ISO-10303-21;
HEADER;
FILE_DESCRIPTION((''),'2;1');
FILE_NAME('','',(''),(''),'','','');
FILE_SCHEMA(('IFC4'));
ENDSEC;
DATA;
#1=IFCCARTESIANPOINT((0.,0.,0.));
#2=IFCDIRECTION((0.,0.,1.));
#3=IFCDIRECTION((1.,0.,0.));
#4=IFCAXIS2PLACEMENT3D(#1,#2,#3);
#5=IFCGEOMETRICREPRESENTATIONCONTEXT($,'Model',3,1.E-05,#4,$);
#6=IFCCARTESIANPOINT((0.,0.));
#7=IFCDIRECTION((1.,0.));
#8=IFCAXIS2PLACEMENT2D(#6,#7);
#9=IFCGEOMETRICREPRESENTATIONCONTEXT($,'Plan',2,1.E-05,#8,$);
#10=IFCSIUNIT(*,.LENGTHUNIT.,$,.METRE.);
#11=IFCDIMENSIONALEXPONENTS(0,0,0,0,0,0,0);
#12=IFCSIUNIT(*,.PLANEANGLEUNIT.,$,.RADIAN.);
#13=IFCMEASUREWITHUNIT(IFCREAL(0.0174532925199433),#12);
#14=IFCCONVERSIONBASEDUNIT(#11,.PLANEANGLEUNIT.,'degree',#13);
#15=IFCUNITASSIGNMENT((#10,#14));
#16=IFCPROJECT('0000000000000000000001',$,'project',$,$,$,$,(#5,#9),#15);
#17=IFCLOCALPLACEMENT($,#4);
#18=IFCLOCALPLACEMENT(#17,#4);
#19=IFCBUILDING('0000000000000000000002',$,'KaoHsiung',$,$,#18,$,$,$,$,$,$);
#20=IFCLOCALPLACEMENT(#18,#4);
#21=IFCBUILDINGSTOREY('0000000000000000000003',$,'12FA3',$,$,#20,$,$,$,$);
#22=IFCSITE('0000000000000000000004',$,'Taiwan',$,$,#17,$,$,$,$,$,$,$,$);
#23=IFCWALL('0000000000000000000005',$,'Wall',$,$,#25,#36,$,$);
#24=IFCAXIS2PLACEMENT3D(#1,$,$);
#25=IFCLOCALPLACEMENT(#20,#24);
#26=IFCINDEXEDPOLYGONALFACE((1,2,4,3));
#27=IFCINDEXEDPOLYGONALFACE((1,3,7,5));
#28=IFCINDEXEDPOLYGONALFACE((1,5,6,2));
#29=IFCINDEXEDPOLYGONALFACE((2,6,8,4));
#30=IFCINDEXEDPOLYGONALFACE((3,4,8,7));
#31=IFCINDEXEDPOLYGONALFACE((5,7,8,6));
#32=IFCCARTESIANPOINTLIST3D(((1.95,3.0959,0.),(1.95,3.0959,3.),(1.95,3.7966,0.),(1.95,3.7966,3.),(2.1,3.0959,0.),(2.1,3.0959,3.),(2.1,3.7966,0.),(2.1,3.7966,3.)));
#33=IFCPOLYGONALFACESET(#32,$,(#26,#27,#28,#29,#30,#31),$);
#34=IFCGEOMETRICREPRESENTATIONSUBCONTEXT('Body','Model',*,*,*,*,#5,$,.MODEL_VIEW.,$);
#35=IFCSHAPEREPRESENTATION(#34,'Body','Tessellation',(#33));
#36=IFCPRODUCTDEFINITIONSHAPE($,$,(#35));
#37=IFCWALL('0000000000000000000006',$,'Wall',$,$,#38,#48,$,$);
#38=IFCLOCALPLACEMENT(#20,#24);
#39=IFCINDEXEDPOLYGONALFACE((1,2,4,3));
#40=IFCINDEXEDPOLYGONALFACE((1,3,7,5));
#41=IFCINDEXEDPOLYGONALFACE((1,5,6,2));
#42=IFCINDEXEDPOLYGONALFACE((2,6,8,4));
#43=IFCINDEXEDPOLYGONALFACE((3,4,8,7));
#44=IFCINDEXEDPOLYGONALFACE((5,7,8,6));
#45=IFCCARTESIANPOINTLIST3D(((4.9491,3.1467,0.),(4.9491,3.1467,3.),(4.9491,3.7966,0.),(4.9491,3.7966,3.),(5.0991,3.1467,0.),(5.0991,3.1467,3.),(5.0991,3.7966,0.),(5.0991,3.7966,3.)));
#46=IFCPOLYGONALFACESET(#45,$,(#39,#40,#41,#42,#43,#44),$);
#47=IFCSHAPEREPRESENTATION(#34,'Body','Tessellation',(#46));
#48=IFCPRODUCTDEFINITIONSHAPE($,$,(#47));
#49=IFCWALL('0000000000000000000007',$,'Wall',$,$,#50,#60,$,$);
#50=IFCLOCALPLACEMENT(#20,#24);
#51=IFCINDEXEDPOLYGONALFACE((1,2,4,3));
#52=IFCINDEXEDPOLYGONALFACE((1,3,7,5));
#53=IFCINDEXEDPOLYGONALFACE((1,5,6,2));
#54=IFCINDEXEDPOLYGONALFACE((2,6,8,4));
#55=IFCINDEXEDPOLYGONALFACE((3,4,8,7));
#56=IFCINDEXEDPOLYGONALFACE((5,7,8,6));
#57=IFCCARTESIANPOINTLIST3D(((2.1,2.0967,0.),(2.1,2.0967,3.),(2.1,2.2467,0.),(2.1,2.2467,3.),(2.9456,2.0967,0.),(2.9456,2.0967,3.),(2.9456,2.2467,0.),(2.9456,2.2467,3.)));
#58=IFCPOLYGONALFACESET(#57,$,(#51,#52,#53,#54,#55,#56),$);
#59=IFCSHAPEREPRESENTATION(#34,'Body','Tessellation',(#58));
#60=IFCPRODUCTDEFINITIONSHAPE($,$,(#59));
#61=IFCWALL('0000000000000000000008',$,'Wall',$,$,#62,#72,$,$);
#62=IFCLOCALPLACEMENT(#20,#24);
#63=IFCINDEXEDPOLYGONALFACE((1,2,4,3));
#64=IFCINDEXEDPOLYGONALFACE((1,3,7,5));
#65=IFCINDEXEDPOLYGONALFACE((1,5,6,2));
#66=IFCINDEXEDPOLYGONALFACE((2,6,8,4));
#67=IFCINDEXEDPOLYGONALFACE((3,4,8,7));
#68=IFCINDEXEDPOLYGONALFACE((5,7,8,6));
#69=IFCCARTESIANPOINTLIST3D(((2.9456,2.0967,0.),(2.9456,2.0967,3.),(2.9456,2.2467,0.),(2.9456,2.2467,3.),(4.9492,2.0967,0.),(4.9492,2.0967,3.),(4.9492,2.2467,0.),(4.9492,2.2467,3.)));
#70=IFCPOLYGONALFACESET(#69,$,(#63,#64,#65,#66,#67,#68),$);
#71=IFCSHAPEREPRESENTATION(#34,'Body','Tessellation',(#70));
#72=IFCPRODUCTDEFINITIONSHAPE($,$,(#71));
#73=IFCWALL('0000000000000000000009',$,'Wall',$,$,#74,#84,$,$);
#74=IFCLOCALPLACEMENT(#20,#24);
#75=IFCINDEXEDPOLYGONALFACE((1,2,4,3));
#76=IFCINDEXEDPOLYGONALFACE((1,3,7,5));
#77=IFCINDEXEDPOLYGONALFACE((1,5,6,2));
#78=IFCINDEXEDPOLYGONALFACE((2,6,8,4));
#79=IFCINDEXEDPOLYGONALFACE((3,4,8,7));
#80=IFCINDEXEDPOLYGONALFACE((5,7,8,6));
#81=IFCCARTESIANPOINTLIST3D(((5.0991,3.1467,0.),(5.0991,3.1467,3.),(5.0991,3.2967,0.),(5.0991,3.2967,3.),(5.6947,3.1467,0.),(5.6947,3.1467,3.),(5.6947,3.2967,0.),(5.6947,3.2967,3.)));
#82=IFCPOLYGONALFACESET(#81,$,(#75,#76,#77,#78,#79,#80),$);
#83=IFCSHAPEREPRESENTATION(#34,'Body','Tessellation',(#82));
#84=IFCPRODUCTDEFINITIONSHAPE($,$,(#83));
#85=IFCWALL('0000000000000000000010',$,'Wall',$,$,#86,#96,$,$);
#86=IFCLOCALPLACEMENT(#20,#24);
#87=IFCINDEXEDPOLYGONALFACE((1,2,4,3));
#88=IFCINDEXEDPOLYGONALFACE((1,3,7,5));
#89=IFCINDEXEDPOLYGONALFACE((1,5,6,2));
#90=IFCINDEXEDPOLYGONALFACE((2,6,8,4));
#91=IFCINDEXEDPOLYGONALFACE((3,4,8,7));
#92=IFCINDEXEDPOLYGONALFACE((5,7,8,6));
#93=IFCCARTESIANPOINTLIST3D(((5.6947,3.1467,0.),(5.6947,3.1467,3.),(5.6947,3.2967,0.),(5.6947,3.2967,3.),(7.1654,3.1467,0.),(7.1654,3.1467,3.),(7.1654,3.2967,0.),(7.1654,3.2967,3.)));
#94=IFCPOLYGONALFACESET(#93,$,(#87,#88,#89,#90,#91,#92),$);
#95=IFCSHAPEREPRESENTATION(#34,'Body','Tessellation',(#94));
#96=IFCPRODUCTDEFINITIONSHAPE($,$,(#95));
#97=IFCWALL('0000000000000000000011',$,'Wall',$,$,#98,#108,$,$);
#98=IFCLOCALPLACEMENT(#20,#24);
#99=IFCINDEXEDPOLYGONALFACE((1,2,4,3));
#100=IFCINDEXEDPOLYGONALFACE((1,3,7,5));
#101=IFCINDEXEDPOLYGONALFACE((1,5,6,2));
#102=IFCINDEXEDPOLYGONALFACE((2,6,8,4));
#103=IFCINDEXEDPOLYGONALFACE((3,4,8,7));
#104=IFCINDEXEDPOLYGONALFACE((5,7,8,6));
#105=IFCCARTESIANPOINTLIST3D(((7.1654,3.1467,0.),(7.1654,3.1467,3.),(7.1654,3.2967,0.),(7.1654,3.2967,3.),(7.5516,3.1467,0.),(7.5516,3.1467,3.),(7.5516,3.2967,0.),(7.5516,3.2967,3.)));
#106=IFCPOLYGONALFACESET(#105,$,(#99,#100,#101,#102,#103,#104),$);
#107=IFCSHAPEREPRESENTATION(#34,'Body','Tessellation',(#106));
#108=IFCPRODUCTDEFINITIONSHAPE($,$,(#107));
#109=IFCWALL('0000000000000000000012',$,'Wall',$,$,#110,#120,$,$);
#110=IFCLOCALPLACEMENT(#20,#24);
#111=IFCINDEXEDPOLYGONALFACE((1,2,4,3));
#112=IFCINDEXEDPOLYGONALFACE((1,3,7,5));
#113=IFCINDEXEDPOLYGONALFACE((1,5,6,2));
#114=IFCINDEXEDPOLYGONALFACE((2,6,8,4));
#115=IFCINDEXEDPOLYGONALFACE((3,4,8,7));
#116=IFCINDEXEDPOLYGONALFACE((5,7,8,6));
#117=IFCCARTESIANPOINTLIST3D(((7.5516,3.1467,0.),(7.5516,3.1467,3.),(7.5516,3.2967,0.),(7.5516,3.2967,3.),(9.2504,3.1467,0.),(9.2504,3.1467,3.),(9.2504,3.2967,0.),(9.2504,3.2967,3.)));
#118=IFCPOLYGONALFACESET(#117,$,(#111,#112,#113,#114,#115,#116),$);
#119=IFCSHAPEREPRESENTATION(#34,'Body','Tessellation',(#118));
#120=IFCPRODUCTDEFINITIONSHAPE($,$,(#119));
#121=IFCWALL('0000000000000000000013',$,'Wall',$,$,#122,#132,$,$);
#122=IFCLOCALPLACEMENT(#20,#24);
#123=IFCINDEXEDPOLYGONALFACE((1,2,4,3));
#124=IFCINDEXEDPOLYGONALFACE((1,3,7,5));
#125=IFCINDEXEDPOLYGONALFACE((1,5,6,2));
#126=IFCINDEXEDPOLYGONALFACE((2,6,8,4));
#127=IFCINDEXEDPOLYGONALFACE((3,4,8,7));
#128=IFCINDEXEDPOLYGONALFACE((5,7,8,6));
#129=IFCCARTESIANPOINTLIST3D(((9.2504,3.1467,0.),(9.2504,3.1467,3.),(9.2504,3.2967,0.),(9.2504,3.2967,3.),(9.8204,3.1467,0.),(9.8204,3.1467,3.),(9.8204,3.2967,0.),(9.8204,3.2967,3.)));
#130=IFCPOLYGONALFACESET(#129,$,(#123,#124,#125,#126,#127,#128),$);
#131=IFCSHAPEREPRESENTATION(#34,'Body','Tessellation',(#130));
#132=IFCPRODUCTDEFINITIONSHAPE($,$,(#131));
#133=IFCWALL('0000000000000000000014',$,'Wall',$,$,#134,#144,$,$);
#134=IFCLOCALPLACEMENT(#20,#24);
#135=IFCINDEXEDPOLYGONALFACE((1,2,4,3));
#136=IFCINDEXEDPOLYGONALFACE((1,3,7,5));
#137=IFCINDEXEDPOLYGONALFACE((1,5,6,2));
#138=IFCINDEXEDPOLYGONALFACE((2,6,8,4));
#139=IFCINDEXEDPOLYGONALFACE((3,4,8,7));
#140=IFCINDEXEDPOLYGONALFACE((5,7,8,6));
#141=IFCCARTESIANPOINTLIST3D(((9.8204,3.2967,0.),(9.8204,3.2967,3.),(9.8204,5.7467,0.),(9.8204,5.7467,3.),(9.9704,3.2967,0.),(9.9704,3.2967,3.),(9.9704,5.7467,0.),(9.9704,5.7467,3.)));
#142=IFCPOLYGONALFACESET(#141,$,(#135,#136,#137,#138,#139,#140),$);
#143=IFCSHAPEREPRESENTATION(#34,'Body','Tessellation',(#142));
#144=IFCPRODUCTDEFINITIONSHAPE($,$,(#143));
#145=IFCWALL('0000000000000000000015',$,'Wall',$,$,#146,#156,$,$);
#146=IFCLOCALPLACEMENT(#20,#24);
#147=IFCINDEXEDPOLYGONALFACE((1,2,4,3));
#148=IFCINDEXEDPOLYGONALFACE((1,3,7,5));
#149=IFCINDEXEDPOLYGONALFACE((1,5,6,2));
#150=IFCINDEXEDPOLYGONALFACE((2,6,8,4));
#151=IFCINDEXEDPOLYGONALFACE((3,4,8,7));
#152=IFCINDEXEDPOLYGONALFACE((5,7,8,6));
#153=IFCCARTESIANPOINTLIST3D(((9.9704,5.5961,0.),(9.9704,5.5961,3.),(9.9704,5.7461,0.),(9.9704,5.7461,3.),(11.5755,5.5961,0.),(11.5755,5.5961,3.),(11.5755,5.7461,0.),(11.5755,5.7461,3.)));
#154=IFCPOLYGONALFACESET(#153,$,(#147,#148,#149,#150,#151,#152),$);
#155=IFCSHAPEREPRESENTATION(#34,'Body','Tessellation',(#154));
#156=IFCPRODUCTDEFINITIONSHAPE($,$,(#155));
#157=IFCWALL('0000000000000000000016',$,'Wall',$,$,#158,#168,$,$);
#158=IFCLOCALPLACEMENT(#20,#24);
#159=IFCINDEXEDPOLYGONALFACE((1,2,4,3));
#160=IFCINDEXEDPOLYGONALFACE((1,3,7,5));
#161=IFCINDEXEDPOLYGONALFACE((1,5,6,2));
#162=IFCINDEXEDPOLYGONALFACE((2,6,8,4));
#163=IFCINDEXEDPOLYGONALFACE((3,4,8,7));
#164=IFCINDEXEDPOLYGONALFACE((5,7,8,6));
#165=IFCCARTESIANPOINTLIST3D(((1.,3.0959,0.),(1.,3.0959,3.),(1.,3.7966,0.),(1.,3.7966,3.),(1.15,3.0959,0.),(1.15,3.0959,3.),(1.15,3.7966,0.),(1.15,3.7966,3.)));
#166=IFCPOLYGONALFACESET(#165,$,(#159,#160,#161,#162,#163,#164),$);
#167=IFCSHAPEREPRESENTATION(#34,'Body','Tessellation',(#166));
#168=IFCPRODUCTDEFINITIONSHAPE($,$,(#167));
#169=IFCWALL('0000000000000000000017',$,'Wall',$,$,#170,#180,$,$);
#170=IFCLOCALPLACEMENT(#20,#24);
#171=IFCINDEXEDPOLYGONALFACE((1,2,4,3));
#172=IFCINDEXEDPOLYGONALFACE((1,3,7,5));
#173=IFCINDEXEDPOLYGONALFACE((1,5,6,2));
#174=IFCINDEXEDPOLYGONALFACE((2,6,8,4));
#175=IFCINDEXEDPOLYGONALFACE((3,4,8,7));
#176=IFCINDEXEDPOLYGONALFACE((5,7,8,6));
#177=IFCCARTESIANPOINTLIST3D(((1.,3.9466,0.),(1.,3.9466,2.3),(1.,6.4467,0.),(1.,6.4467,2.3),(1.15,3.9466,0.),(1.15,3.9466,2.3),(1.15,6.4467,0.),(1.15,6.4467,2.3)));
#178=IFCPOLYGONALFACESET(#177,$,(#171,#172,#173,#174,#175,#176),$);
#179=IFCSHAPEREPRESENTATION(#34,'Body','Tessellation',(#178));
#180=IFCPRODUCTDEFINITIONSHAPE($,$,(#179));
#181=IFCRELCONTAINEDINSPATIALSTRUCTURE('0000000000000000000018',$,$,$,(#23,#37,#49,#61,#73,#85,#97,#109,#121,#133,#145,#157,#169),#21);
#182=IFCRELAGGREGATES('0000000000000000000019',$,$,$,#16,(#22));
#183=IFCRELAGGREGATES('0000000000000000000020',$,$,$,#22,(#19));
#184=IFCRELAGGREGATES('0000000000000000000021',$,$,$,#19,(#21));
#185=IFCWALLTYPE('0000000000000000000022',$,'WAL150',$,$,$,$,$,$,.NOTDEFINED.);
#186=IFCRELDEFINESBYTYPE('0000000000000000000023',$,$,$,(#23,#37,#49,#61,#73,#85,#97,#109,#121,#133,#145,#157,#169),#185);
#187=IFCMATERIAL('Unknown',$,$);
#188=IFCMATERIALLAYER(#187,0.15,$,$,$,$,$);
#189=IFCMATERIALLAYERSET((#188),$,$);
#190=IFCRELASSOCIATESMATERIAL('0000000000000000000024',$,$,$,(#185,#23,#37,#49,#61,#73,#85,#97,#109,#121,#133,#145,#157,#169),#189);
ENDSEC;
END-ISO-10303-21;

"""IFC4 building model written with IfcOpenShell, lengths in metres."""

from ifc_helpers import new_model, entity, si_unit, converted_unit, frame, origin_with_axes, origin_2d_with_axis, place, context, subcontext, project, spatial, line, indexed_curve, outline, extrude, material, layer, layer_set, layer_usage, type_object, element, save


model = new_model("IFC4")

# Units and contexts
model_context = context("Model", 3, precision=1e-05, world=origin_with_axes())
plan_context = context("Plan", 2, precision=1e-05, world=origin_2d_with_axis())
body_context_1 = subcontext(model_context, "Body", "Model", "MODEL_VIEW")
ifc_project = project(units=[si_unit("LENGTHUNIT", "METRE"), converted_unit("PLANEANGLEUNIT", "degree", entity("IfcReal", 0.0174532925199433), si_unit("PLANEANGLEUNIT", "RADIAN"), dimensions=[0, 0, 0, 0, 0, 0, 0])], contexts=[model_context, plan_context])

# Site, building, storey
site_placement = place(None, origin_with_axes())
site = spatial("IfcSite", under=ifc_project, at=site_placement, Name="Taiwan")
building_placement = place(site_placement, origin_with_axes())
building = spatial("IfcBuilding", under=site, at=building_placement, Name="KaoHsiung")
storey_placement = place(building_placement, origin_with_axes())
storey = spatial("IfcBuildingStorey", under=building, at=storey_placement, Name="12FA3")

# Shared definitions
ifc_material = material(Name="Unknown")

# Walls
ifc_layer_1 = layer(ifc_material, 0.15)
ifc_layer_set_1 = layer_set([ifc_layer_1])
wall_type_1 = type_object("IfcWallType", Name="WAL150", PredefinedType="NOTDEFINED", material=ifc_layer_set_1)
ifc_layer_usage_1 = layer_usage(ifc_layer_set_1, "AXIS2", "POSITIVE", 0.0)
wall_1_placement = place(storey_placement, frame((1.95, 3.7966, 0.0), z_axis=(0.0, 0.0, 1.0), x_axis=(0.0, -1.0, 0.0)))
element("IfcWall", 1, at=wall_1_placement, inside=storey, type_object=wall_type_1, material=ifc_layer_usage_1, Name="Wall", context=body_context_1, shape_type="SweptSolid", body=[
    extrude(outline(indexed_curve([(0.0, 0.0), (0.0, 0.15), (0.7007, 0.15), (0.7007, 0.0)], segments=[line(1, 2, 3, 4, 1)])), origin_with_axes(), (0.0, 0.0, 1.0), 3.0),
])
ifc_layer_usage_2 = layer_usage(ifc_layer_set_1, "AXIS2", "POSITIVE", 0.0)
wall_2_placement = place(storey_placement, frame((4.9491, 3.7966, 0.0), z_axis=(0.0, 0.0, 1.0), x_axis=(0.0, -1.0, 0.0)))
element("IfcWall", 2, at=wall_2_placement, inside=storey, type_object=wall_type_1, material=ifc_layer_usage_2, Name="Wall", context=body_context_1, shape_type="SweptSolid", body=[
    extrude(outline(indexed_curve([(0.0, 0.0), (0.0, 0.15), (0.6499, 0.15), (0.6499, 0.0)], segments=[line(1, 2, 3, 4, 1)])), origin_with_axes(), (0.0, 0.0, 1.0), 3.0),
])
ifc_layer_usage_3 = layer_usage(ifc_layer_set_1, "AXIS2", "POSITIVE", 0.0)
wall_3_placement = place(storey_placement, frame((2.1, 2.0967, 0.0), z_axis=(0.0, 0.0, 1.0), x_axis=(1.0, 0.0, 0.0)))
element("IfcWall", 3, at=wall_3_placement, inside=storey, type_object=wall_type_1, material=ifc_layer_usage_3, Name="Wall", context=body_context_1, shape_type="SweptSolid", body=[
    extrude(outline(indexed_curve([(0.0, 0.0), (0.0, 0.15), (0.8456, 0.15), (0.8456, 0.0)], segments=[line(1, 2, 3, 4, 1)])), origin_with_axes(), (0.0, 0.0, 1.0), 3.0),
])
ifc_layer_usage_4 = layer_usage(ifc_layer_set_1, "AXIS2", "POSITIVE", 0.0)
wall_4_placement = place(storey_placement, frame((2.9456, 2.0967, 0.0), z_axis=(0.0, 0.0, 1.0), x_axis=(1.0, 0.0, 0.0)))
element("IfcWall", 4, at=wall_4_placement, inside=storey, type_object=wall_type_1, material=ifc_layer_usage_4, Name="Wall", context=body_context_1, shape_type="SweptSolid", body=[
    extrude(outline(indexed_curve([(0.0, 0.0), (0.0, 0.15), (2.0037, 0.15), (2.0037, 0.0)], segments=[line(1, 2, 3, 4, 1)])), origin_with_axes(), (0.0, 0.0, 1.0), 3.0),
])
ifc_layer_usage_5 = layer_usage(ifc_layer_set_1, "AXIS2", "POSITIVE", 0.0)
wall_5_placement = place(storey_placement, frame((5.0991, 3.1467, 0.0), z_axis=(0.0, 0.0, 1.0), x_axis=(1.0, 0.0, 0.0)))
element("IfcWall", 5, at=wall_5_placement, inside=storey, type_object=wall_type_1, material=ifc_layer_usage_5, Name="Wall", context=body_context_1, shape_type="SweptSolid", body=[
    extrude(outline(indexed_curve([(0.0, 0.0), (0.0, 0.15), (0.5956, 0.15), (0.5956, 0.0)], segments=[line(1, 2, 3, 4, 1)])), origin_with_axes(), (0.0, 0.0, 1.0), 3.0),
])
ifc_layer_usage_6 = layer_usage(ifc_layer_set_1, "AXIS2", "POSITIVE", 0.0)
wall_6_placement = place(storey_placement, frame((5.6947, 3.1467, 0.0), z_axis=(0.0, 0.0, 1.0), x_axis=(1.0, 0.0, 0.0)))
element("IfcWall", 6, at=wall_6_placement, inside=storey, type_object=wall_type_1, material=ifc_layer_usage_6, Name="Wall", context=body_context_1, shape_type="SweptSolid", body=[
    extrude(outline(indexed_curve([(0.0, 0.0), (0.0, 0.15), (1.4706, 0.15), (1.4706, 0.0)], segments=[line(1, 2, 3, 4, 1)])), origin_with_axes(), (0.0, 0.0, 1.0), 3.0),
])
ifc_layer_usage_7 = layer_usage(ifc_layer_set_1, "AXIS2", "POSITIVE", 0.0)
wall_7_placement = place(storey_placement, frame((7.1654, 3.1467, 0.0), z_axis=(0.0, 0.0, 1.0), x_axis=(1.0, 0.0, 0.0)))
element("IfcWall", 7, at=wall_7_placement, inside=storey, type_object=wall_type_1, material=ifc_layer_usage_7, Name="Wall", context=body_context_1, shape_type="SweptSolid", body=[
    extrude(outline(indexed_curve([(0.0, 0.0), (0.0, 0.15), (0.3862, 0.15), (0.3862, 0.0)], segments=[line(1, 2, 3, 4, 1)])), origin_with_axes(), (0.0, 0.0, 1.0), 3.0),
])
ifc_layer_usage_8 = layer_usage(ifc_layer_set_1, "AXIS2", "POSITIVE", 0.0)
wall_8_placement = place(storey_placement, frame((7.5516, 3.1467, 0.0), z_axis=(0.0, 0.0, 1.0), x_axis=(1.0, 0.0, 0.0)))
element("IfcWall", 8, at=wall_8_placement, inside=storey, type_object=wall_type_1, material=ifc_layer_usage_8, Name="Wall", context=body_context_1, shape_type="SweptSolid", body=[
    extrude(outline(indexed_curve([(0.0, 0.0), (0.0, 0.15), (1.6987, 0.15), (1.6987, 0.0)], segments=[line(1, 2, 3, 4, 1)])), origin_with_axes(), (0.0, 0.0, 1.0), 3.0),
])
ifc_layer_usage_9 = layer_usage(ifc_layer_set_1, "AXIS2", "POSITIVE", 0.0)
wall_9_placement = place(storey_placement, frame((9.2504, 3.1467, 0.0), z_axis=(0.0, 0.0, 1.0), x_axis=(1.0, 0.0, 0.0)))
element("IfcWall", 9, at=wall_9_placement, inside=storey, type_object=wall_type_1, material=ifc_layer_usage_9, Name="Wall", context=body_context_1, shape_type="SweptSolid", body=[
    extrude(outline(indexed_curve([(0.0, 0.0), (0.0, 0.15), (0.57, 0.15), (0.57, 0.0)], segments=[line(1, 2, 3, 4, 1)])), origin_with_axes(), (0.0, 0.0, 1.0), 3.0),
])
ifc_layer_usage_10 = layer_usage(ifc_layer_set_1, "AXIS2", "POSITIVE", 0.0)
wall_10_placement = place(storey_placement, frame((9.9704, 3.2967, 0.0), z_axis=(0.0, 0.0, 1.0), x_axis=(0.0, 1.0, 0.0)))
element("IfcWall", 10, at=wall_10_placement, inside=storey, type_object=wall_type_1, material=ifc_layer_usage_10, Name="Wall", context=body_context_1, shape_type="SweptSolid", body=[
    extrude(outline(indexed_curve([(0.0, 0.0), (0.0, 0.15), (2.45, 0.15), (2.45, 0.0)], segments=[line(1, 2, 3, 4, 1)])), origin_with_axes(), (0.0, 0.0, 1.0), 3.0),
])
ifc_layer_usage_11 = layer_usage(ifc_layer_set_1, "AXIS2", "POSITIVE", 0.0)
wall_11_placement = place(storey_placement, frame((9.9704, 5.5961, 0.0), z_axis=(0.0, 0.0, 1.0), x_axis=(1.0, 0.0, 0.0)))
element("IfcWall", 11, at=wall_11_placement, inside=storey, type_object=wall_type_1, material=ifc_layer_usage_11, Name="Wall", context=body_context_1, shape_type="SweptSolid", body=[
    extrude(outline(indexed_curve([(0.0, 0.0), (0.0, 0.15), (1.6051, 0.15), (1.6051, 0.0)], segments=[line(1, 2, 3, 4, 1)])), origin_with_axes(), (0.0, 0.0, 1.0), 3.0),
])
ifc_layer_usage_12 = layer_usage(ifc_layer_set_1, "AXIS2", "POSITIVE", 0.0)
wall_12_placement = place(storey_placement, frame((1.0, 3.7966, 0.0), z_axis=(0.0, 0.0, 1.0), x_axis=(0.0, -1.0, 0.0)))
element("IfcWall", 12, at=wall_12_placement, inside=storey, type_object=wall_type_1, material=ifc_layer_usage_12, Name="Wall", context=body_context_1, shape_type="SweptSolid", body=[
    extrude(outline(indexed_curve([(0.0, 0.0), (0.0, 0.15), (0.7007, 0.15), (0.7007, 0.0)], segments=[line(1, 2, 3, 4, 1)])), origin_with_axes(), (0.0, 0.0, 1.0), 3.0),
])
ifc_layer_usage_13 = layer_usage(ifc_layer_set_1, "AXIS2", "POSITIVE", 0.0)
wall_13_placement = place(storey_placement, frame((1.0, 6.4467, 0.0), z_axis=(0.0, 0.0, 1.0), x_axis=(0.0, -1.0, 0.0)))
element("IfcWall", 13, at=wall_13_placement, inside=storey, type_object=wall_type_1, material=ifc_layer_usage_13, Name="Wall", context=body_context_1, shape_type="SweptSolid", body=[
    extrude(outline(indexed_curve([(0.0, 0.0), (0.0, 0.15), (2.5001, 0.15), (2.5001, 0.0)], segments=[line(1, 2, 3, 4, 1)])), origin_with_axes(), (0.0, 0.0, 1.0), 2.3),
])

save(model, "model.ifc")
